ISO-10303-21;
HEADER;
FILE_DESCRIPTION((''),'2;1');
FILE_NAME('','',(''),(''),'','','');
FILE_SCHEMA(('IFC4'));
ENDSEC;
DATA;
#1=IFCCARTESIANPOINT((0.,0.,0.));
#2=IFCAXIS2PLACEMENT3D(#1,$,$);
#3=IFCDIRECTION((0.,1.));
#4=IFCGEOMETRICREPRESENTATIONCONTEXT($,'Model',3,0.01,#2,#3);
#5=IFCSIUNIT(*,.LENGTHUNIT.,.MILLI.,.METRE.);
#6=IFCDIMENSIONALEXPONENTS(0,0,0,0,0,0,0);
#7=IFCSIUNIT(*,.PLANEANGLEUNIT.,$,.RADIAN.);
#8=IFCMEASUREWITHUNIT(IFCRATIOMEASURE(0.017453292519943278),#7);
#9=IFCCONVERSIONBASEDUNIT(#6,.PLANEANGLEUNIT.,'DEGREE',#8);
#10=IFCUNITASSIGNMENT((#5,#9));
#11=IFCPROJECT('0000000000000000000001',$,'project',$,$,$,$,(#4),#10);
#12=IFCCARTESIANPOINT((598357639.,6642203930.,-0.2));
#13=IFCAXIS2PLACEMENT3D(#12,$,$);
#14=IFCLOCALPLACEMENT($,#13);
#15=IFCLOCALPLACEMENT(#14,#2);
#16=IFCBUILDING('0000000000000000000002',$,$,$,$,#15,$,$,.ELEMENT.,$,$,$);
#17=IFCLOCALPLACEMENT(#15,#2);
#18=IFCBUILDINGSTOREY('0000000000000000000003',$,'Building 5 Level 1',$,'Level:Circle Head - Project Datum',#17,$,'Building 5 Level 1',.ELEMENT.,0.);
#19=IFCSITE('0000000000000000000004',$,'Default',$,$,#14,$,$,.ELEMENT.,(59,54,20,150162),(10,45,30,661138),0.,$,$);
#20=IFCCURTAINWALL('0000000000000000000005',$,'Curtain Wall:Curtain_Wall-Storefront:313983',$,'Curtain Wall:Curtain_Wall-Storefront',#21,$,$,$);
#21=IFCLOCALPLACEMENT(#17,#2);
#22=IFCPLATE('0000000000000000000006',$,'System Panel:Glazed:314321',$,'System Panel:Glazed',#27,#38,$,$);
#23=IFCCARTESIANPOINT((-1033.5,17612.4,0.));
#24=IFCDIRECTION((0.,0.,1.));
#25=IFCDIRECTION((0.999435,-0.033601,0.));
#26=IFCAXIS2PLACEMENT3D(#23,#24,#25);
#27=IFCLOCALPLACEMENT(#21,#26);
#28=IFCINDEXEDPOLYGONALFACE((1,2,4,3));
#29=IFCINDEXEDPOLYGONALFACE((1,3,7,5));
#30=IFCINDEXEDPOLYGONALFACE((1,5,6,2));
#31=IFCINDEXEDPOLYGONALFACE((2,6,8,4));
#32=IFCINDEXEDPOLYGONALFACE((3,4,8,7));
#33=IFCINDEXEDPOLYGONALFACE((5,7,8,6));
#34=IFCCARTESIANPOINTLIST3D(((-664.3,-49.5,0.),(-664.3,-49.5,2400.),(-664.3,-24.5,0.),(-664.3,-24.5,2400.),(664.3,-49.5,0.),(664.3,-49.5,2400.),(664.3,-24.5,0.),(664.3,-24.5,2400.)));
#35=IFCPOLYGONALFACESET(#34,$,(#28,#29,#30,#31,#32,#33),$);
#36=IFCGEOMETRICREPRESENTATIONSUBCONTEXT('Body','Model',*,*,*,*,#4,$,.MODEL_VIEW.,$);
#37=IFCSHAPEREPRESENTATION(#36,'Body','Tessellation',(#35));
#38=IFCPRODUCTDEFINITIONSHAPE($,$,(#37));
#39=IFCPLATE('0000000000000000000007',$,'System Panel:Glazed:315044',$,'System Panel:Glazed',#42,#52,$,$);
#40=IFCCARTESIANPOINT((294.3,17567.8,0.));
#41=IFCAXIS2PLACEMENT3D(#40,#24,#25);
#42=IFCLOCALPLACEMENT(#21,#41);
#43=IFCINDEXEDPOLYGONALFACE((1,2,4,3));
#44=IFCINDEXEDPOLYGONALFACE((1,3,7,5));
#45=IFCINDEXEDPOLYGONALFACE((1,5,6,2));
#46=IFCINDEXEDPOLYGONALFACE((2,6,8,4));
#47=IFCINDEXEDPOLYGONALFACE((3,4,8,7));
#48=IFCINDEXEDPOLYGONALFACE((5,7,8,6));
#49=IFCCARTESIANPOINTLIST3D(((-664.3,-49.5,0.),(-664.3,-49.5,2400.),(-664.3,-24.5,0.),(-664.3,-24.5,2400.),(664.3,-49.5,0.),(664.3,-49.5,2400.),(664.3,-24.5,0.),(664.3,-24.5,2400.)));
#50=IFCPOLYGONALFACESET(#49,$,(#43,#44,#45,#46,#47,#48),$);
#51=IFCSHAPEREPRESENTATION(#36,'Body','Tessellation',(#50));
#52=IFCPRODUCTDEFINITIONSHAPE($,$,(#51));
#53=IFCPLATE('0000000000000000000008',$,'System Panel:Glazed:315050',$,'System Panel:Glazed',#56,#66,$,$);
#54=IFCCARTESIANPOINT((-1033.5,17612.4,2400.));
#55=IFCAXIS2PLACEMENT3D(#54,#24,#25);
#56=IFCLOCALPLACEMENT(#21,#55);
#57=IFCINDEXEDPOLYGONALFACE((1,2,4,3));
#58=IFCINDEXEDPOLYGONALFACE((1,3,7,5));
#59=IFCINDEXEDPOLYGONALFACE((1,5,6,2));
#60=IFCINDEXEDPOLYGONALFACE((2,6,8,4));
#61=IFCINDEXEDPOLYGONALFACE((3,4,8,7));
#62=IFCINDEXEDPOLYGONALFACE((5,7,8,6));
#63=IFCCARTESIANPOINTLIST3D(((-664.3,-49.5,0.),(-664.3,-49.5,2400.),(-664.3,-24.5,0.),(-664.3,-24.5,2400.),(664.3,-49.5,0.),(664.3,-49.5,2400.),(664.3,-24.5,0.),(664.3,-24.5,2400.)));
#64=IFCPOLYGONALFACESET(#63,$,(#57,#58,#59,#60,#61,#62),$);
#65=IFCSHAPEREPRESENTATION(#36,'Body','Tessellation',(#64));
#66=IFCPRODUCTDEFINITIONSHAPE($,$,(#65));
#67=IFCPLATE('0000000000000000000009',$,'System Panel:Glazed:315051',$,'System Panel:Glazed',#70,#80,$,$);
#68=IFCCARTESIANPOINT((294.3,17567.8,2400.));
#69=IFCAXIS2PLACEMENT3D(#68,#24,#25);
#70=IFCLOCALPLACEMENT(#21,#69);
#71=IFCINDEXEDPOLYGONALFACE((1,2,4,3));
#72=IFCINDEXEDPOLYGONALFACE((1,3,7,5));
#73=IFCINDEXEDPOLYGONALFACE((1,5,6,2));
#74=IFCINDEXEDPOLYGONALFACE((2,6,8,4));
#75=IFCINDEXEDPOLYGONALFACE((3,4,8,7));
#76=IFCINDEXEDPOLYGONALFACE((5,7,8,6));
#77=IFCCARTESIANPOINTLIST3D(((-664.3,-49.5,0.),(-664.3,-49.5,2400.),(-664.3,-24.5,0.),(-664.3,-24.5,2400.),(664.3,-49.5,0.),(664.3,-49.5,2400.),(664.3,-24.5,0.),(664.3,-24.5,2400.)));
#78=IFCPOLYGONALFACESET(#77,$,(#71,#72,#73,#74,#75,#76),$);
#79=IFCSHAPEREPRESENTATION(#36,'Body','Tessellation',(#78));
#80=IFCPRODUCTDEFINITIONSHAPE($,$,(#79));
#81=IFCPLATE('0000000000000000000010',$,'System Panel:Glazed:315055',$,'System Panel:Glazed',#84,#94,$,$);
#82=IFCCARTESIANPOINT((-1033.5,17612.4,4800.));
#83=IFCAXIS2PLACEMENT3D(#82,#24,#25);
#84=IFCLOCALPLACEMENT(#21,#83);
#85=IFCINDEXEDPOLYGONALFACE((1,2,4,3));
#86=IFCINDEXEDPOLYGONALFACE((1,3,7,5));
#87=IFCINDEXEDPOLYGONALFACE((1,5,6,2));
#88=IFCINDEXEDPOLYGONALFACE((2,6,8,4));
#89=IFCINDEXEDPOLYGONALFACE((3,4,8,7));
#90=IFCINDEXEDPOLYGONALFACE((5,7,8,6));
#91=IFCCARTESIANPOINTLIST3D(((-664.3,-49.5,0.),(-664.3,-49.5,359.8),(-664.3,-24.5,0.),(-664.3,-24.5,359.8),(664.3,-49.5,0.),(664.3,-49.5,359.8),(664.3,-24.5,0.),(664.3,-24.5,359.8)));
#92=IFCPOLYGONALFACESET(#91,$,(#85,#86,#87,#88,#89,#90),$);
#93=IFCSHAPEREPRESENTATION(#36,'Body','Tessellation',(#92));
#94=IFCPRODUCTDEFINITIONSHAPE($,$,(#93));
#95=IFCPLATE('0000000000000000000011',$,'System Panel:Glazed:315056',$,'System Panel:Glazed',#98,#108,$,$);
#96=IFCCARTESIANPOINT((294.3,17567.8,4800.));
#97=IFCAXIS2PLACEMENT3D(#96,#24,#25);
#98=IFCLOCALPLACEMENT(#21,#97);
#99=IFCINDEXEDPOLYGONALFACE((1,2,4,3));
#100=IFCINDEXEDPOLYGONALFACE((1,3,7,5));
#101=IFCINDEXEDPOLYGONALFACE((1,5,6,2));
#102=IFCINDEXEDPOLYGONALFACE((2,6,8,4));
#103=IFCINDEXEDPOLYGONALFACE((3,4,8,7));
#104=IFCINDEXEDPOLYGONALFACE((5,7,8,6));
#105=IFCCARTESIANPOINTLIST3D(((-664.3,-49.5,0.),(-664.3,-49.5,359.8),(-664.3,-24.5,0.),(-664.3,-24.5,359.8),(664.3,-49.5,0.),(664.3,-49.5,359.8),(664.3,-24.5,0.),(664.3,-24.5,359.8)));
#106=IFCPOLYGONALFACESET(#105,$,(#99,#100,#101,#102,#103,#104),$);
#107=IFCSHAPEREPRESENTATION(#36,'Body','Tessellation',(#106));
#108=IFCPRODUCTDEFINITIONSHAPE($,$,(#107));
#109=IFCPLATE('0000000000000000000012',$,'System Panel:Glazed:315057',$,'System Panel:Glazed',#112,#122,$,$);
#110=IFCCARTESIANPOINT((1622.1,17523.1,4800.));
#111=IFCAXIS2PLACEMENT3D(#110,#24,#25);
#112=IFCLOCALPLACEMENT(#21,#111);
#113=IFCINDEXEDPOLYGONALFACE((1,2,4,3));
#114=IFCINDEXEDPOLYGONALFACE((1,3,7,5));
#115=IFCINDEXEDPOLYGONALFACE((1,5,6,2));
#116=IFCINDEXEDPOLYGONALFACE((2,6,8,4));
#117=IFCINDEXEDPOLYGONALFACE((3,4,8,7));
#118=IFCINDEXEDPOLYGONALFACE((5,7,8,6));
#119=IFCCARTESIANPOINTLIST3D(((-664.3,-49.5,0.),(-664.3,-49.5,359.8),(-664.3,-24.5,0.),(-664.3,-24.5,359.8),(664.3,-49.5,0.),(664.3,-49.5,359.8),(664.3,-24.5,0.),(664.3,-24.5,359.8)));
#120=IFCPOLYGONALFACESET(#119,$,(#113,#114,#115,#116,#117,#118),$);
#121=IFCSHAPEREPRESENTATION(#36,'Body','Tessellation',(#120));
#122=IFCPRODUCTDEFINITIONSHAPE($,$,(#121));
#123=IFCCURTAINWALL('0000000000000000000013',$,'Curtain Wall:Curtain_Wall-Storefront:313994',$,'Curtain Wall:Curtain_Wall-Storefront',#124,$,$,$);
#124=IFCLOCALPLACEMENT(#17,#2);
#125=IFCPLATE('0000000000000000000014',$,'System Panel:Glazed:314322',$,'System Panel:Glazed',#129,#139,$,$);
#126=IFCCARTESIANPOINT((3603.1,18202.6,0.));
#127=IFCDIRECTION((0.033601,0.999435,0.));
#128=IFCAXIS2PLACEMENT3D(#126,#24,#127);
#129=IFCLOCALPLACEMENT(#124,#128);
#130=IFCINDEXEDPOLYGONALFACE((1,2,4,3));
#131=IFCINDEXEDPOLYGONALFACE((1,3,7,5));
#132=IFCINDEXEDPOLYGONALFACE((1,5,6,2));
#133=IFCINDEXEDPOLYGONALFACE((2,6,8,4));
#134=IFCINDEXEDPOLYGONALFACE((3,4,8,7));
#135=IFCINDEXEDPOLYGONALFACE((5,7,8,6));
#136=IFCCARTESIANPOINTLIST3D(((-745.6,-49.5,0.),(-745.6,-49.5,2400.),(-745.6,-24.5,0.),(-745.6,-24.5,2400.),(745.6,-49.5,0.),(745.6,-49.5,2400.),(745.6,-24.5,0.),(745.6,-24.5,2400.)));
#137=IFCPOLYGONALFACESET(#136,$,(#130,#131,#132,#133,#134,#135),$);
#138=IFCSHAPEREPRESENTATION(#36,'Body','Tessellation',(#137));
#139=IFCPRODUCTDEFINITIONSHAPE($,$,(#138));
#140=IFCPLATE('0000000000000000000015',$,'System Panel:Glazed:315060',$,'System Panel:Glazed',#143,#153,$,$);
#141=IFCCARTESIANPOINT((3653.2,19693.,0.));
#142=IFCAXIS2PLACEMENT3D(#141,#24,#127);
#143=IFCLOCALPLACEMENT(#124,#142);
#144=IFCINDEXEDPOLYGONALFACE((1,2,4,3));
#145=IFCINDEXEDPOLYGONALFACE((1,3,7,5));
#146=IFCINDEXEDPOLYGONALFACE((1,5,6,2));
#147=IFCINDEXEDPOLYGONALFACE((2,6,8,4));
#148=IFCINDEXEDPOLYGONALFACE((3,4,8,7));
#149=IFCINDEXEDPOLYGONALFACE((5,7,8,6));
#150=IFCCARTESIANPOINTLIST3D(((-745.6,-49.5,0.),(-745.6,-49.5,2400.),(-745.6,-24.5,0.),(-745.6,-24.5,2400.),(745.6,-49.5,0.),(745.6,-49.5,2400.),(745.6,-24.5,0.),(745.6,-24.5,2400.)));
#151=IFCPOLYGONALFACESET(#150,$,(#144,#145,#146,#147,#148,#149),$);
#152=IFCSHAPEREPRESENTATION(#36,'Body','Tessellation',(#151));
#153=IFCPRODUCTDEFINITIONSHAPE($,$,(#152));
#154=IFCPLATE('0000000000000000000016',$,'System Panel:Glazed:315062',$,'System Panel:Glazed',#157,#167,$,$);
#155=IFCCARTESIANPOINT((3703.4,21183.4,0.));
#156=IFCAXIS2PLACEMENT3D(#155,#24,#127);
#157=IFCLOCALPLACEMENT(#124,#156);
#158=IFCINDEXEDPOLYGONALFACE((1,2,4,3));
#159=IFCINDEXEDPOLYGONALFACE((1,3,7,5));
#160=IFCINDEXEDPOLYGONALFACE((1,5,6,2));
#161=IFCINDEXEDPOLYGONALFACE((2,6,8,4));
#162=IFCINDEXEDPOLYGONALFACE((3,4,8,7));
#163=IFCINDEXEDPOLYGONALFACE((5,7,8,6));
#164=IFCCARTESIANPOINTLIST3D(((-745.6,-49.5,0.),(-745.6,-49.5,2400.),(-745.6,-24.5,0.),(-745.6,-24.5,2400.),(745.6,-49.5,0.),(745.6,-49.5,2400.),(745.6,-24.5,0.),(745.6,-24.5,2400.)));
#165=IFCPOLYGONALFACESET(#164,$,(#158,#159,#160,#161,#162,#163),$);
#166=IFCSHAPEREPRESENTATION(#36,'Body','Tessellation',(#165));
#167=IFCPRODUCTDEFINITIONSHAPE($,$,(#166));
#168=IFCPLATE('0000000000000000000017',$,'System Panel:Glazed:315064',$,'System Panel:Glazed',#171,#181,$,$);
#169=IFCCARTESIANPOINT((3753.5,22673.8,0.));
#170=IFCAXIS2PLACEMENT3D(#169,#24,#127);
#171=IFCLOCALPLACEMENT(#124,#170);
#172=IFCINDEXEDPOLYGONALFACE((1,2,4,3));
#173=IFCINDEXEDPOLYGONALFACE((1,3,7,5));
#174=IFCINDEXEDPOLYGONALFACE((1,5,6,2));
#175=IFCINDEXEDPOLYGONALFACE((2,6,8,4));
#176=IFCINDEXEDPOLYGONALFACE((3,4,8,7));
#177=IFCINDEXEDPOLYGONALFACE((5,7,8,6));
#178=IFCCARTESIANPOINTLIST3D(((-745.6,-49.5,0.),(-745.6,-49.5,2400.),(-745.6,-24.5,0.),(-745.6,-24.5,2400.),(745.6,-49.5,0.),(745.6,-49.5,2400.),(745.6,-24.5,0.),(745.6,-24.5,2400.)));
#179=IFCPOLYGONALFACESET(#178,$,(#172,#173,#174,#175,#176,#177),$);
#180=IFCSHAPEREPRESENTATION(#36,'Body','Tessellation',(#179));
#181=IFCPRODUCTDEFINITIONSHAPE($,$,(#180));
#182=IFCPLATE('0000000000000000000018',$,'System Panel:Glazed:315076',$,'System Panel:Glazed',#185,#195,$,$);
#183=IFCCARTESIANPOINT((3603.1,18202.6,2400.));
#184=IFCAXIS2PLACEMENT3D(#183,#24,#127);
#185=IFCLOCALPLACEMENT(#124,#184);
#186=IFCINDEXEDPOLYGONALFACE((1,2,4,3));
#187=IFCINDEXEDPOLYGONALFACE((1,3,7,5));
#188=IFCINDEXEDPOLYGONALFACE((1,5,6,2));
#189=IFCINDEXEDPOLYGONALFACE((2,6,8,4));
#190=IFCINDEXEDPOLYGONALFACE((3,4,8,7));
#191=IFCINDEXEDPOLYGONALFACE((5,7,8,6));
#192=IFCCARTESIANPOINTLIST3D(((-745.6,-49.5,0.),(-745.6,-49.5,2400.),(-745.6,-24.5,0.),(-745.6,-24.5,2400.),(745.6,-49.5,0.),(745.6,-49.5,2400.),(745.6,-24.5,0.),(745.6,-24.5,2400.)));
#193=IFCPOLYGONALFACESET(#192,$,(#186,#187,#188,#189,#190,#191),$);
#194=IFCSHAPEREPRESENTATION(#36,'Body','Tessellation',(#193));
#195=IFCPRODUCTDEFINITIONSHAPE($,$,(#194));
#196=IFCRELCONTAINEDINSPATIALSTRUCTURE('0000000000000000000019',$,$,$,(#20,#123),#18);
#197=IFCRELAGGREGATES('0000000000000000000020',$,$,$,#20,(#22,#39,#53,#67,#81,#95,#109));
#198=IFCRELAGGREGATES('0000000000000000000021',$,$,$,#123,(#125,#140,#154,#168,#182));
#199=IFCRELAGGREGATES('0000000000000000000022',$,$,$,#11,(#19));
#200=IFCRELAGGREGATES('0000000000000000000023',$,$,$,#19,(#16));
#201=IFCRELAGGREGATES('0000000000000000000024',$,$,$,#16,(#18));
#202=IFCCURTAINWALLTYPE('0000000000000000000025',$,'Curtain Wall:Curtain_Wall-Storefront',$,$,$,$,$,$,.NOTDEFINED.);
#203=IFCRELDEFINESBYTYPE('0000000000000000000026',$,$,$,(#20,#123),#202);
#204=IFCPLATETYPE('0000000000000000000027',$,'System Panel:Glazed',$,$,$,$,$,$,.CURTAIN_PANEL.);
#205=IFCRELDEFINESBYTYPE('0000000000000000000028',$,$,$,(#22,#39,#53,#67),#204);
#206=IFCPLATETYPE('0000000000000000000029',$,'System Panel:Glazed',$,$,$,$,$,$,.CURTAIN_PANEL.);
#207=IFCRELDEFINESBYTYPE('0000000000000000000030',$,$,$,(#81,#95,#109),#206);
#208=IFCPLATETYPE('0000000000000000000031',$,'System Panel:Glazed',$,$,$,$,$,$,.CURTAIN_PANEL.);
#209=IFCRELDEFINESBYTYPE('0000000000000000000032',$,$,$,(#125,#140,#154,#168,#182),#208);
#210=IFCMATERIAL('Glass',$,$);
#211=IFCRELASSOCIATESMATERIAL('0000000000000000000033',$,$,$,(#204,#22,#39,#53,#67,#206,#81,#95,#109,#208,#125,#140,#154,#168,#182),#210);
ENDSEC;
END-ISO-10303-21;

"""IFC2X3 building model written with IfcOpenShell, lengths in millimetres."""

from ifc_helpers import new_model, entity, si_unit, converted_unit, direction, frame, frame_2d, origin, place, context, subcontext, project, spatial, rectangle, extrude, source, transform, mapped, material, type_object, type_shapes, element, aggregate, save


model = new_model("IFC2X3")

# Units and contexts
model_context = context("Model", 3, precision=0.01, world=origin(), true_north=direction((0.0, 1.0)))
body_context = subcontext(model_context, "Body", "Model", "MODEL_VIEW")
ifc_project = project(units=[si_unit("LENGTHUNIT", "METRE", prefix="MILLI"), converted_unit("PLANEANGLEUNIT", "DEGREE", entity("IfcRatioMeasure", 0.017453292519943278), si_unit("PLANEANGLEUNIT", "RADIAN"), dimensions=[0, 0, 0, 0, 0, 0, 0])], contexts=[model_context])

# Site, building, storey
site_placement = place(None, frame((598357639.0, 6642203930.0, -0.2)))
site = spatial("IfcSite", under=ifc_project, at=site_placement, Name="Default", CompositionType="ELEMENT", RefLatitude=(59, 54, 20, 150162), RefLongitude=(10, 45, 30, 661138), RefElevation=0.0)
building_placement = place(site_placement, origin())
building = spatial("IfcBuilding", under=site, at=building_placement, CompositionType="ELEMENT")
storey_placement = place(building_placement, origin())
storey = spatial("IfcBuildingStorey", under=building, at=storey_placement, Name="Building 5 Level 1", ObjectType="Level:Circle Head - Project Datum", LongName="Building 5 Level 1", CompositionType="ELEMENT", Elevation=0.0)

# Curtain walls, plates
curtain_wall_type = type_object("IfcCurtainWallType", Name="Curtain Wall:Curtain_Wall-Storefront", PredefinedType="NOTDEFINED")
ifc_material = material(Name="Glass")
curtain_wall_1_placement = place(storey_placement, origin())
curtain_wall_1 = element("IfcCurtainWall", 1, at=curtain_wall_1_placement, inside=storey, type_object=curtain_wall_type, Name="Curtain Wall:Curtain_Wall-Storefront:313983", ObjectType="Curtain Wall:Curtain_Wall-Storefront")
plate_type_1 = type_object("IfcPlateType", Name="System Panel:Glazed", PredefinedType="CURTAIN_PANEL", material=ifc_material)
shared_shape_1 = source(origin(), body_context, "Body", "SweptSolid", [
    extrude(rectangle(XDim=25.0, YDim=1328.6, at=frame_2d((0.0, 0.0), x_axis=(1.0, 0.0))), frame((0.0, -37.0, 0.0), z_axis=(0.0, 0.0, 1.0), x_axis=(0.0, 1.0, 0.0)), (0.0, 0.0, 1.0), 2400.0),
])
type_shapes(plate_type_1, [shared_shape_1])
plate_1_placement = place(curtain_wall_1_placement, frame((-1033.5, 17612.4, 0.0), z_axis=(0.0, 0.0, 1.0), x_axis=(0.999435, -0.033601, 0.0)))
plate_1 = element("IfcPlate", 2, at=plate_1_placement, type_object=plate_type_1, material=ifc_material, Name="System Panel:Glazed:314321", ObjectType="System Panel:Glazed", context=body_context, shape_type="MappedRepresentation", body=[
    mapped(shared_shape_1, transform((0.0, 0.0, 0.0), scale=1.0)),
])
plate_2_placement = place(curtain_wall_1_placement, frame((294.3, 17567.8, 0.0), z_axis=(0.0, 0.0, 1.0), x_axis=(0.999435, -0.033601, 0.0)))
plate_2 = element("IfcPlate", 3, at=plate_2_placement, type_object=plate_type_1, material=ifc_material, Name="System Panel:Glazed:315044", ObjectType="System Panel:Glazed", context=body_context, shape_type="MappedRepresentation", body=[
    mapped(shared_shape_1, transform((0.0, 0.0, 0.0), scale=1.0)),
])
plate_3_placement = place(curtain_wall_1_placement, frame((-1033.5, 17612.4, 2400.0), z_axis=(0.0, 0.0, 1.0), x_axis=(0.999435, -0.033601, 0.0)))
plate_3 = element("IfcPlate", 4, at=plate_3_placement, type_object=plate_type_1, material=ifc_material, Name="System Panel:Glazed:315050", ObjectType="System Panel:Glazed", context=body_context, shape_type="MappedRepresentation", body=[
    mapped(shared_shape_1, transform((0.0, 0.0, 0.0), scale=1.0)),
])
plate_4_placement = place(curtain_wall_1_placement, frame((294.3, 17567.8, 2400.0), z_axis=(0.0, 0.0, 1.0), x_axis=(0.999435, -0.033601, 0.0)))
plate_4 = element("IfcPlate", 5, at=plate_4_placement, type_object=plate_type_1, material=ifc_material, Name="System Panel:Glazed:315051", ObjectType="System Panel:Glazed", context=body_context, shape_type="MappedRepresentation", body=[
    mapped(shared_shape_1, transform((0.0, 0.0, 0.0), scale=1.0)),
])
plate_type_2 = type_object("IfcPlateType", Name="System Panel:Glazed", PredefinedType="CURTAIN_PANEL", material=ifc_material)
shared_shape_2 = source(origin(), body_context, "Body", "SweptSolid", [
    extrude(rectangle(XDim=25.0, YDim=1328.6, at=frame_2d((0.0, 0.0), x_axis=(1.0, 0.0))), frame((0.0, -37.0, 0.0), z_axis=(0.0, 0.0, 1.0), x_axis=(0.0, 1.0, 0.0)), (0.0, 0.0, 1.0), 359.8),
])
type_shapes(plate_type_2, [shared_shape_2])
plate_5_placement = place(curtain_wall_1_placement, frame((-1033.5, 17612.4, 4800.0), z_axis=(0.0, 0.0, 1.0), x_axis=(0.999435, -0.033601, 0.0)))
plate_5 = element("IfcPlate", 6, at=plate_5_placement, type_object=plate_type_2, material=ifc_material, Name="System Panel:Glazed:315055", ObjectType="System Panel:Glazed", context=body_context, shape_type="MappedRepresentation", body=[
    mapped(shared_shape_2, transform((0.0, 0.0, 0.0), scale=1.0)),
])
plate_6_placement = place(curtain_wall_1_placement, frame((294.3, 17567.8, 4800.0), z_axis=(0.0, 0.0, 1.0), x_axis=(0.999435, -0.033601, 0.0)))
plate_6 = element("IfcPlate", 7, at=plate_6_placement, type_object=plate_type_2, material=ifc_material, Name="System Panel:Glazed:315056", ObjectType="System Panel:Glazed", context=body_context, shape_type="MappedRepresentation", body=[
    mapped(shared_shape_2, transform((0.0, 0.0, 0.0), scale=1.0)),
])
plate_7_placement = place(curtain_wall_1_placement, frame((1622.1, 17523.1, 4800.0), z_axis=(0.0, 0.0, 1.0), x_axis=(0.999435, -0.033601, 0.0)))
plate_7 = element("IfcPlate", 8, at=plate_7_placement, type_object=plate_type_2, material=ifc_material, Name="System Panel:Glazed:315057", ObjectType="System Panel:Glazed", context=body_context, shape_type="MappedRepresentation", body=[
    mapped(shared_shape_2, transform((0.0, 0.0, 0.0), scale=1.0)),
])
aggregate(curtain_wall_1, [plate_1, plate_2, plate_3, plate_4, plate_5, plate_6, plate_7])
curtain_wall_2_placement = place(storey_placement, origin())
curtain_wall_2 = element("IfcCurtainWall", 9, at=curtain_wall_2_placement, inside=storey, type_object=curtain_wall_type, Name="Curtain Wall:Curtain_Wall-Storefront:313994", ObjectType="Curtain Wall:Curtain_Wall-Storefront")
plate_type_3 = type_object("IfcPlateType", Name="System Panel:Glazed", PredefinedType="CURTAIN_PANEL", material=ifc_material)
shared_shape_3 = source(origin(), body_context, "Body", "SweptSolid", [
    extrude(rectangle(XDim=25.0, YDim=1491.2, at=frame_2d((0.0, 0.0), x_axis=(1.0, 0.0))), frame((0.0, -37.0, 0.0), z_axis=(0.0, 0.0, 1.0), x_axis=(0.0, 1.0, 0.0)), (0.0, 0.0, 1.0), 2400.0),
])
type_shapes(plate_type_3, [shared_shape_3])
plate_8_placement = place(curtain_wall_2_placement, frame((3603.1, 18202.6, 0.0), z_axis=(0.0, 0.0, 1.0), x_axis=(0.033601, 0.999435, 0.0)))
plate_8 = element("IfcPlate", 10, at=plate_8_placement, type_object=plate_type_3, material=ifc_material, Name="System Panel:Glazed:314322", ObjectType="System Panel:Glazed", context=body_context, shape_type="MappedRepresentation", body=[
    mapped(shared_shape_3, transform((0.0, 0.0, 0.0), scale=1.0)),
])
plate_9_placement = place(curtain_wall_2_placement, frame((3653.2, 19693.0, 0.0), z_axis=(0.0, 0.0, 1.0), x_axis=(0.033601, 0.999435, 0.0)))
plate_9 = element("IfcPlate", 11, at=plate_9_placement, type_object=plate_type_3, material=ifc_material, Name="System Panel:Glazed:315060", ObjectType="System Panel:Glazed", context=body_context, shape_type="MappedRepresentation", body=[
    mapped(shared_shape_3, transform((0.0, 0.0, 0.0), scale=1.0)),
])
plate_10_placement = place(curtain_wall_2_placement, frame((3703.4, 21183.4, 0.0), z_axis=(0.0, 0.0, 1.0), x_axis=(0.033601, 0.999435, 0.0)))
plate_10 = element("IfcPlate", 12, at=plate_10_placement, type_object=plate_type_3, material=ifc_material, Name="System Panel:Glazed:315062", ObjectType="System Panel:Glazed", context=body_context, shape_type="MappedRepresentation", body=[
    mapped(shared_shape_3, transform((0.0, 0.0, 0.0), scale=1.0)),
])
plate_11_placement = place(curtain_wall_2_placement, frame((3753.5, 22673.8, 0.0), z_axis=(0.0, 0.0, 1.0), x_axis=(0.033601, 0.999435, 0.0)))
plate_11 = element("IfcPlate", 13, at=plate_11_placement, type_object=plate_type_3, material=ifc_material, Name="System Panel:Glazed:315064", ObjectType="System Panel:Glazed", context=body_context, shape_type="MappedRepresentation", body=[
    mapped(shared_shape_3, transform((0.0, 0.0, 0.0), scale=1.0)),
])
plate_12_placement = place(curtain_wall_2_placement, frame((3603.1, 18202.6, 2400.0), z_axis=(0.0, 0.0, 1.0), x_axis=(0.033601, 0.999435, 0.0)))
plate_12 = element("IfcPlate", 14, at=plate_12_placement, type_object=plate_type_3, material=ifc_material, Name="System Panel:Glazed:315076", ObjectType="System Panel:Glazed", context=body_context, shape_type="MappedRepresentation", body=[
    mapped(shared_shape_3, transform((0.0, 0.0, 0.0), scale=1.0)),
])
aggregate(curtain_wall_2, [plate_8, plate_9, plate_10, plate_11, plate_12])

save(model, "model.ifc")
